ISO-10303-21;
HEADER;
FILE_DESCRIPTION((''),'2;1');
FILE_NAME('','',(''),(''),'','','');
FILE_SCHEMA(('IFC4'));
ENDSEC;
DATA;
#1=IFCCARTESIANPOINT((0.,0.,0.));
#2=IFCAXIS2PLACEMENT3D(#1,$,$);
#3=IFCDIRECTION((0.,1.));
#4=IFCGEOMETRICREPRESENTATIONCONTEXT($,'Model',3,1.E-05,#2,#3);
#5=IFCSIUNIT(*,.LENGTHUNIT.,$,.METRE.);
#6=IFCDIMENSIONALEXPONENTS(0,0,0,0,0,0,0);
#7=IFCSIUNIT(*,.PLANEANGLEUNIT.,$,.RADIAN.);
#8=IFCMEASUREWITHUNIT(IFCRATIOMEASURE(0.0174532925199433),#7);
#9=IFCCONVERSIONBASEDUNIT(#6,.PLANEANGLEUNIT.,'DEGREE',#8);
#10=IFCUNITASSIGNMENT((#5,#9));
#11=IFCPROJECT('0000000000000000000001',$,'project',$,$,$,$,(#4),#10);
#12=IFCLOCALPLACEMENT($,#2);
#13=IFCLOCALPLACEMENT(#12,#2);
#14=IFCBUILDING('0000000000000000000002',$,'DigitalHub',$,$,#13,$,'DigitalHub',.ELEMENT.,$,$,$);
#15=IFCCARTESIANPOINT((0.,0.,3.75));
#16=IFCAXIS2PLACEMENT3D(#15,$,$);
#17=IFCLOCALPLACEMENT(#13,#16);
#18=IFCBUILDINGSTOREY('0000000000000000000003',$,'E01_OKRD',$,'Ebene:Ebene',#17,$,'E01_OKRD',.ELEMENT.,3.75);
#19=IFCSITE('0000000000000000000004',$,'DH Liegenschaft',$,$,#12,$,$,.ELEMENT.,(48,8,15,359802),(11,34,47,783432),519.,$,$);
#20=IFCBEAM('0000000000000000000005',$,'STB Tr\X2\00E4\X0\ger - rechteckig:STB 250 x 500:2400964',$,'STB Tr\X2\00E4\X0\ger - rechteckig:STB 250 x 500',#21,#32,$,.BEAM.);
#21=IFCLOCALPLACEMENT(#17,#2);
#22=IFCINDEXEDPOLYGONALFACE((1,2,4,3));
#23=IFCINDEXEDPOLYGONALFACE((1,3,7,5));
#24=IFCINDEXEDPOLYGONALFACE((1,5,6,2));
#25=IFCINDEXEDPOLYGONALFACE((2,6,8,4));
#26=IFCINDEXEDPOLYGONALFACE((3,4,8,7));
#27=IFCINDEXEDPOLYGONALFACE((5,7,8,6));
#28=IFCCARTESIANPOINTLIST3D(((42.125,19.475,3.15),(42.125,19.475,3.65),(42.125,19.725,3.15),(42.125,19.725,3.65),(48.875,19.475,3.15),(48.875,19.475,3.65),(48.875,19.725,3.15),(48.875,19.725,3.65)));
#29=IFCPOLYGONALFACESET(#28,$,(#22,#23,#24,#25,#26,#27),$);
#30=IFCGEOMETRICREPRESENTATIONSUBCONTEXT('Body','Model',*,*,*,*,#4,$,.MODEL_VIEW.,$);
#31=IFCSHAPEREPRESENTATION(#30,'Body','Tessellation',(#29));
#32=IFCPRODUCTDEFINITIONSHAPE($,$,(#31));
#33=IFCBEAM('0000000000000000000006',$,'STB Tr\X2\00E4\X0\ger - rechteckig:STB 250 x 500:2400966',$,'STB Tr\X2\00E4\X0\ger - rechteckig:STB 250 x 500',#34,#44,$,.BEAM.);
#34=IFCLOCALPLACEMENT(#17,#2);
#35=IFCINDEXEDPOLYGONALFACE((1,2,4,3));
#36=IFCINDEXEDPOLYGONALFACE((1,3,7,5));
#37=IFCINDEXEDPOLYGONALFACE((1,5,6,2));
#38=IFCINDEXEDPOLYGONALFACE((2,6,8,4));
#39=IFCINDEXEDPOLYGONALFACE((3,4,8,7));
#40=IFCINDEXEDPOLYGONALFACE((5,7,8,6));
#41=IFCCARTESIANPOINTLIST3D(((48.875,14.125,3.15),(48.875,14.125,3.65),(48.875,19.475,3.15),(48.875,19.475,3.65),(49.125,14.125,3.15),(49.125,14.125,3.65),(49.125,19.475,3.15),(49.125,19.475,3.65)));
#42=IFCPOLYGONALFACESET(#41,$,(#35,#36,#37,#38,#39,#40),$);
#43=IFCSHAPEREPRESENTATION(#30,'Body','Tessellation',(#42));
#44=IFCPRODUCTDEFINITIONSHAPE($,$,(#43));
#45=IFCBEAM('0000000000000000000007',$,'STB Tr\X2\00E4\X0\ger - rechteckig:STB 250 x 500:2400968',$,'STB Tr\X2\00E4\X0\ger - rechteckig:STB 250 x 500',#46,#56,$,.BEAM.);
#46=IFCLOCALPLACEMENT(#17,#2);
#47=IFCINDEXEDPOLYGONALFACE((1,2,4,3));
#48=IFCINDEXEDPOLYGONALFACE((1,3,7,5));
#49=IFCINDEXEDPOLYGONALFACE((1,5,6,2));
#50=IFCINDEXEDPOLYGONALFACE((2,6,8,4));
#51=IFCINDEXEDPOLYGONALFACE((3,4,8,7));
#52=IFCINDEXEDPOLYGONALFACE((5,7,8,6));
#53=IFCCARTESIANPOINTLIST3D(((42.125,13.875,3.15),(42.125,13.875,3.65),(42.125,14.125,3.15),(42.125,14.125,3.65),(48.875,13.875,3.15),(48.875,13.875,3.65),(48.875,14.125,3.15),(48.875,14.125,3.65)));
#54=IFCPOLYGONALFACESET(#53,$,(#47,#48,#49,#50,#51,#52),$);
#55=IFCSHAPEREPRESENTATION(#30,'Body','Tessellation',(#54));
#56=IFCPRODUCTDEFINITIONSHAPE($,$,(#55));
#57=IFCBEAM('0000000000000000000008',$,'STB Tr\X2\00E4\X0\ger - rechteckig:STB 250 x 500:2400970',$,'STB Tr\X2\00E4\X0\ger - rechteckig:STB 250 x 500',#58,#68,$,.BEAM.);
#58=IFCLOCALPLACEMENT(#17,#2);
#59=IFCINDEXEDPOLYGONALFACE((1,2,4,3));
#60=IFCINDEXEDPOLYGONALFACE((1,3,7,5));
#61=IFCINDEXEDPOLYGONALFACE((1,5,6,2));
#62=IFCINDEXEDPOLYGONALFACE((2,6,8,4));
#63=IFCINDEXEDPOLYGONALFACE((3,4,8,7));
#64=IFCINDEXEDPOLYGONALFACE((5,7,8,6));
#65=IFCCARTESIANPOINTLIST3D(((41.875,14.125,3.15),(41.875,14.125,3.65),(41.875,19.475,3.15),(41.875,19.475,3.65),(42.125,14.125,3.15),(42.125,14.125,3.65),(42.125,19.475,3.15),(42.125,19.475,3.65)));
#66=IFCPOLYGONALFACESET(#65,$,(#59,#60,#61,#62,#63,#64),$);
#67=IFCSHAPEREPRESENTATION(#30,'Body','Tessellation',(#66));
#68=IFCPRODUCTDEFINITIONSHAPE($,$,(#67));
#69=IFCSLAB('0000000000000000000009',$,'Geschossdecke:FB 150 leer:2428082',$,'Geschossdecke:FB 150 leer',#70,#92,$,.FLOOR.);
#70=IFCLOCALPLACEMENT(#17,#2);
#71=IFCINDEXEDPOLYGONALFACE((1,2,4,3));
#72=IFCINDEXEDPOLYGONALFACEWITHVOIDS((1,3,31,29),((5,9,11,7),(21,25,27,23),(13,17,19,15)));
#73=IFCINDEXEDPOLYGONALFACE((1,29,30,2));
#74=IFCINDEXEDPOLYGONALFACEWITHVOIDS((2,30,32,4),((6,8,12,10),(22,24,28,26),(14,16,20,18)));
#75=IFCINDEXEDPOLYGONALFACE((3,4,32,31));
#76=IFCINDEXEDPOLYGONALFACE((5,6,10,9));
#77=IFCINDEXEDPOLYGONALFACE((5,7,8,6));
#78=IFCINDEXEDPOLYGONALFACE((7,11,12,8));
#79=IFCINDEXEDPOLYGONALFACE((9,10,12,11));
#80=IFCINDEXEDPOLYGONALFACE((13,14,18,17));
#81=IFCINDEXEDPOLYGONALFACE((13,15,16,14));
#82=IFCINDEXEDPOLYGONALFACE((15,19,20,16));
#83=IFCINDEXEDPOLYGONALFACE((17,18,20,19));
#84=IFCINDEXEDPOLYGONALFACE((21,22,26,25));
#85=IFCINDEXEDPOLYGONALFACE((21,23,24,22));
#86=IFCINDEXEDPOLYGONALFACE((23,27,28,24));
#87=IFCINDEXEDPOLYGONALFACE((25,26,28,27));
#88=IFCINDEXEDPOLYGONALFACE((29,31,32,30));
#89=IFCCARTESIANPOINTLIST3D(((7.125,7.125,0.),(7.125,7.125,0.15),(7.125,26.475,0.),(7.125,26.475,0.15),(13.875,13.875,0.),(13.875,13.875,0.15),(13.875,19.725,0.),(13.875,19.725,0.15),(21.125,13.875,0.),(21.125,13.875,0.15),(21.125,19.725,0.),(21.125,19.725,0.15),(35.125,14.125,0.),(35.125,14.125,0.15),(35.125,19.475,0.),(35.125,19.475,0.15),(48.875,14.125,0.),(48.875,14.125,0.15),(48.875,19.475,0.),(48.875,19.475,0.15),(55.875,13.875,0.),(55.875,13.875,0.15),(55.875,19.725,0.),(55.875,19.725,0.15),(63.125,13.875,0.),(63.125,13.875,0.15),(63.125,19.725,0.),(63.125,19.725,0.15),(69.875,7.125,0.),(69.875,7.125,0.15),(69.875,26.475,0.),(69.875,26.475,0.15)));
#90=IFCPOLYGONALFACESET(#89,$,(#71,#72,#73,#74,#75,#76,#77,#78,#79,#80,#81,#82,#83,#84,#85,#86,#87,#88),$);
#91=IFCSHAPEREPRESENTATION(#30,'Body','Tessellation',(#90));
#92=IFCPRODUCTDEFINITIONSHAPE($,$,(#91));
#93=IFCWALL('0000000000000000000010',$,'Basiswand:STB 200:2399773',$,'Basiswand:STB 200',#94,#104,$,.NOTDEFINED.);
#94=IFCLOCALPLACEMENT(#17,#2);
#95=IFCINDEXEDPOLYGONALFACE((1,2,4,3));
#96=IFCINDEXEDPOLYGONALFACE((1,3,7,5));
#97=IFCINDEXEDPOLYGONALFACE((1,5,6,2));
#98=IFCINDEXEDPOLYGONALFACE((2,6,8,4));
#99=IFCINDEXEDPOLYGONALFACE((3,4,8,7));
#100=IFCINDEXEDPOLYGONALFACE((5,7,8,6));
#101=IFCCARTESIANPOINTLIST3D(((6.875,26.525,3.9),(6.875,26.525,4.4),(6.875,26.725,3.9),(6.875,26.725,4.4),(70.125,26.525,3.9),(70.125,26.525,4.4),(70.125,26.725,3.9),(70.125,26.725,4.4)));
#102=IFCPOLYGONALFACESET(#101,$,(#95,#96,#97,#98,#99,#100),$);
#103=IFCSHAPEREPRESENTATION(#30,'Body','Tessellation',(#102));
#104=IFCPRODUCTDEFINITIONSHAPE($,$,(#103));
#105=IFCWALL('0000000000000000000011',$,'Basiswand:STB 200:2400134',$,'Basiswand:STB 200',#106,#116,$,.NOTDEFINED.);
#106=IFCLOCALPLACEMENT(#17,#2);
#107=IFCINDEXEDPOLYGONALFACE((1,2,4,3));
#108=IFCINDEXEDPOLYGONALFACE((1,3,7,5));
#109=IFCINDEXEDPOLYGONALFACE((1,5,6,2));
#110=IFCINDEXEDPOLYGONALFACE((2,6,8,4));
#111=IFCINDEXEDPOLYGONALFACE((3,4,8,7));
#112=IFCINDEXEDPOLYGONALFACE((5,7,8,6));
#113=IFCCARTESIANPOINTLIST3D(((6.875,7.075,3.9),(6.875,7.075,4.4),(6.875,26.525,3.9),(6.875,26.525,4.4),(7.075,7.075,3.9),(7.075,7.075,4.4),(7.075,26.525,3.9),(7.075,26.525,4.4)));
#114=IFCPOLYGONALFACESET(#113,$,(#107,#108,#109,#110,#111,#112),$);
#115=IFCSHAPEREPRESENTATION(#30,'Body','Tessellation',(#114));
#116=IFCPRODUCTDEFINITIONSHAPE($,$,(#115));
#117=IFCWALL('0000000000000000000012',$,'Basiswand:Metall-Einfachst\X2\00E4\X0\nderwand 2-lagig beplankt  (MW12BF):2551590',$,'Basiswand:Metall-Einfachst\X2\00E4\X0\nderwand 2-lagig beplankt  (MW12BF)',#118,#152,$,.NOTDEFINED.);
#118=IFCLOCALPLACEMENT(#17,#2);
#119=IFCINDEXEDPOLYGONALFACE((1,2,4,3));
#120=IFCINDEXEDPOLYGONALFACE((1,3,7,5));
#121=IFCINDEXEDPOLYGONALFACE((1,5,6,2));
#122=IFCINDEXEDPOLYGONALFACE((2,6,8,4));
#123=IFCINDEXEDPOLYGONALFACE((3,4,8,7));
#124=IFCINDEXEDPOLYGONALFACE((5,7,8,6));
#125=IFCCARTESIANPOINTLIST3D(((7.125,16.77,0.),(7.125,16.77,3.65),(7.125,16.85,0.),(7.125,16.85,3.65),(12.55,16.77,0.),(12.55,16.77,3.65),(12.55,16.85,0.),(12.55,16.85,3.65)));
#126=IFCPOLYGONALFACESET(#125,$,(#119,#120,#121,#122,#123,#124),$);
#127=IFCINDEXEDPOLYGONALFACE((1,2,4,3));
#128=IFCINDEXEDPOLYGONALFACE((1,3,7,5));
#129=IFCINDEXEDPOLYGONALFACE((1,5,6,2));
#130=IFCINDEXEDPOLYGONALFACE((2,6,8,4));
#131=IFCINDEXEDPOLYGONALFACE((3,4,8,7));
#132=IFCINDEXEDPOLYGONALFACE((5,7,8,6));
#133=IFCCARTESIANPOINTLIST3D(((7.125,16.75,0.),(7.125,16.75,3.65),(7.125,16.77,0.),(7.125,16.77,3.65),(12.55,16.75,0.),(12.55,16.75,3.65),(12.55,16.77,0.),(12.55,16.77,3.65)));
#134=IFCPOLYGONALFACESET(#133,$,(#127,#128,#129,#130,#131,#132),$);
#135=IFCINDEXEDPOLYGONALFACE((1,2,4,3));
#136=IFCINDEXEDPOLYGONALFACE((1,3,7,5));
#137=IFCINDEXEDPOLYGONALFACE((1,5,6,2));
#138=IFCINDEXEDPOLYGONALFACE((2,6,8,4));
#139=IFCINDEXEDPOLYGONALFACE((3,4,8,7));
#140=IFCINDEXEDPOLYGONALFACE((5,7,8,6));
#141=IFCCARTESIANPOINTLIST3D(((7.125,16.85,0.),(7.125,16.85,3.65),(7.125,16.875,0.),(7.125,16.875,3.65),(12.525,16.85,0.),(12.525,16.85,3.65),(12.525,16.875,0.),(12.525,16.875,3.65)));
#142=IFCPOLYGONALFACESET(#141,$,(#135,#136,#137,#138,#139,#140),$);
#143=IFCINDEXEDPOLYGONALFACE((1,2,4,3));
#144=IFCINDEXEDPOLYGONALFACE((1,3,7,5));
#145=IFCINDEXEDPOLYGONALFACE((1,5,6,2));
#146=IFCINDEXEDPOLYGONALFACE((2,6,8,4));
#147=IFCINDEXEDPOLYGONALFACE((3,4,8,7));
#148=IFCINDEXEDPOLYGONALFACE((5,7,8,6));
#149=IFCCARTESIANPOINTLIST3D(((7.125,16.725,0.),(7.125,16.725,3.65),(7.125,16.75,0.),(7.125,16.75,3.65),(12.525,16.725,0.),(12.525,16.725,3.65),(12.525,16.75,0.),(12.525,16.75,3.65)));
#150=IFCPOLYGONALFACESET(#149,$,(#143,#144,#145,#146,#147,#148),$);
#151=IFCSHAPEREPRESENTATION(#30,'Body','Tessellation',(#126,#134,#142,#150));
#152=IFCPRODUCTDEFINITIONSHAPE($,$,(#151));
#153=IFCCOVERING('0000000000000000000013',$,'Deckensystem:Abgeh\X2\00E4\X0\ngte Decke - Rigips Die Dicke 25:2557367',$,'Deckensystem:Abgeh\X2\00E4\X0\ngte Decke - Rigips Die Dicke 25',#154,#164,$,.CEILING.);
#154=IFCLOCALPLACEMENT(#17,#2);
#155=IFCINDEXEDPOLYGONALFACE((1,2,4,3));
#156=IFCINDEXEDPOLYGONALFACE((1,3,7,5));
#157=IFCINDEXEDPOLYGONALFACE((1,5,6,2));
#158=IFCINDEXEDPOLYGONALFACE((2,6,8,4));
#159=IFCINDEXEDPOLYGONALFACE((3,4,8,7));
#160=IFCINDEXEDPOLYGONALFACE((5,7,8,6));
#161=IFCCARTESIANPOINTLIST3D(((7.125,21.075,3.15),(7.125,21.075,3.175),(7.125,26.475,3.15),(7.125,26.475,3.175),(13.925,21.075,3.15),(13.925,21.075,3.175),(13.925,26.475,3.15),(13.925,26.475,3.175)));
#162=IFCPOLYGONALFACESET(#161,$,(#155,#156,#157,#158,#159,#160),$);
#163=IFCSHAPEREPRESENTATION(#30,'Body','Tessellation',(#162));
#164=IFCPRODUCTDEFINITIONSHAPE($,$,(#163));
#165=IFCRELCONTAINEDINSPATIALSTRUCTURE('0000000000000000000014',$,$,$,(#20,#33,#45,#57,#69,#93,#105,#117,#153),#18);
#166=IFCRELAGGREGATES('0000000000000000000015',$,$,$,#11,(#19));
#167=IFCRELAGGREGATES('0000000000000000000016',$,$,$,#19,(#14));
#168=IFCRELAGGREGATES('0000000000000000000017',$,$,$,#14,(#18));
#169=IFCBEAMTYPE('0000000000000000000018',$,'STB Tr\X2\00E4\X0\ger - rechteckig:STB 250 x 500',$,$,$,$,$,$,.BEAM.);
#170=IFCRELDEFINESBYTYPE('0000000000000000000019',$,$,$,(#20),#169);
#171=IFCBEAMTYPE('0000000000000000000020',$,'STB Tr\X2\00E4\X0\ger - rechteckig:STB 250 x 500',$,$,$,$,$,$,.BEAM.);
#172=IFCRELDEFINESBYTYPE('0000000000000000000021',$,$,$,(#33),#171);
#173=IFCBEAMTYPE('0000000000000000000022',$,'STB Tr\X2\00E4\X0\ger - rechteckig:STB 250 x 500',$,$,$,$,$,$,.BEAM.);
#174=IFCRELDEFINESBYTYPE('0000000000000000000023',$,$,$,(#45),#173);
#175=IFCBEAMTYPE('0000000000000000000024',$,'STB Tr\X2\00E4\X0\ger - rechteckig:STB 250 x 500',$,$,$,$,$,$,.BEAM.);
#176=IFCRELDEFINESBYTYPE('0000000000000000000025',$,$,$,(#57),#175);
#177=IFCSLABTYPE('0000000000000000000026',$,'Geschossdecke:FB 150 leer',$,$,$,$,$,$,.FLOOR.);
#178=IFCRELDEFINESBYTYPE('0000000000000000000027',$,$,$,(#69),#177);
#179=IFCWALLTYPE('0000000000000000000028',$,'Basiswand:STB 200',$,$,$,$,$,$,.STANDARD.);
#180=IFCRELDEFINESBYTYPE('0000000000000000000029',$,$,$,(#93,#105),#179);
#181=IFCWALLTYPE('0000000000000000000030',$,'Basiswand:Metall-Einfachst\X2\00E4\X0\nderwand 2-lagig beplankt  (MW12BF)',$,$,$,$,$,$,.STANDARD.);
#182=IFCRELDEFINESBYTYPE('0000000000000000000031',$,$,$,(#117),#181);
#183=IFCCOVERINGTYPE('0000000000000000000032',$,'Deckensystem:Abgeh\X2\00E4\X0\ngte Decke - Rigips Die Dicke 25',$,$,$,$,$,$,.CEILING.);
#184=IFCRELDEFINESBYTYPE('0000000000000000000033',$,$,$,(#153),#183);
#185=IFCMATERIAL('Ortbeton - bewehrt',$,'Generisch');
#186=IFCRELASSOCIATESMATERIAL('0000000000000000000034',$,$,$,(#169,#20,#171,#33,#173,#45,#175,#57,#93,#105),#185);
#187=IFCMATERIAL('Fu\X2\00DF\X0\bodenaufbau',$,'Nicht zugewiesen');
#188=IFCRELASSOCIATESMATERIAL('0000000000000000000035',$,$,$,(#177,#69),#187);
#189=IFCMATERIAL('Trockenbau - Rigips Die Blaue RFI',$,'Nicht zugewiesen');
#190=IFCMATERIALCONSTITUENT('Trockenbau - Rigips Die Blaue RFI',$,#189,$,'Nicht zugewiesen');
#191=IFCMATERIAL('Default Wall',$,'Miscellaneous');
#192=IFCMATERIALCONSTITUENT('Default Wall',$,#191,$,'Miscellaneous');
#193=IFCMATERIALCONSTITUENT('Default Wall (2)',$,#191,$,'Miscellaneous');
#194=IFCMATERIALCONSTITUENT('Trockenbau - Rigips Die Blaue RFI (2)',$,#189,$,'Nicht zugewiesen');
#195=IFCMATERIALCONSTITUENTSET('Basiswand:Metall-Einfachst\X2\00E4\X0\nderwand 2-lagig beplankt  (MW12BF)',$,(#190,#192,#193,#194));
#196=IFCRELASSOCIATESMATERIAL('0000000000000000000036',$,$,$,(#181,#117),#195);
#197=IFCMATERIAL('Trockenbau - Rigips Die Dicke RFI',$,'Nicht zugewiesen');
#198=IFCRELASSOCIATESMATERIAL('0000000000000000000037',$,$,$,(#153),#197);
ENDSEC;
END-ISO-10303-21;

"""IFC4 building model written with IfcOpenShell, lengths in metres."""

from ifc_helpers import new_model, entity, si_unit, converted_unit, direction, frame, origin, place, context, subcontext, project, spatial, indexed_curve, outline, extrude, source, transform, mapped, material, constituent, constituent_set, type_object, type_shapes, element, save


model = new_model("IFC4")

# Units and contexts
model_context = context("Model", 3, precision=1e-05, world=origin(), true_north=direction((0.0, 1.0)))
body_context = subcontext(model_context, "Body", "Model", "MODEL_VIEW")
ifc_project = project(units=[si_unit("LENGTHUNIT", "METRE"), converted_unit("PLANEANGLEUNIT", "DEGREE", entity("IfcRatioMeasure", 0.0174532925199433), si_unit("PLANEANGLEUNIT", "RADIAN"), dimensions=[0, 0, 0, 0, 0, 0, 0])], contexts=[model_context])

# Site, building, storey
site_placement = place(None, frame((0.0, 0.0, 0.0)))
site = spatial("IfcSite", under=ifc_project, at=site_placement, Name="DH Liegenschaft", CompositionType="ELEMENT", RefLatitude=(48, 8, 15, 359802), RefLongitude=(11, 34, 47, 783432), RefElevation=519.0)
building_placement = place(site_placement, origin())
building = spatial("IfcBuilding", under=site, at=building_placement, Name="DigitalHub", LongName="DigitalHub", CompositionType="ELEMENT")
storey_placement = place(building_placement, frame((0.0, 0.0, 3.75)))
storey = spatial("IfcBuildingStorey", under=building, at=storey_placement, Name="E01_OKRD", ObjectType="Ebene:Ebene", LongName="E01_OKRD", CompositionType="ELEMENT", Elevation=3.75)

# Shared definitions
ifc_material_1 = material(Name="Ortbeton - bewehrt", Category="Generisch")

# Beams
beam_type_1 = type_object("IfcBeamType", Name="STB Träger - rechteckig:STB 250 x 500", PredefinedType="BEAM", material=ifc_material_1)
shared_shape_1 = source(origin(), body_context, "Body", "SweptSolid", [
    extrude(outline(indexed_curve([(-0.25, -0.125), (0.25, -0.125), (0.25, 0.125), (-0.25, 0.125), (-0.25, -0.125)], self_intersect=False)), frame((42.125, 19.6, 7.15), z_axis=(1.0, 0.0, 0.0), x_axis=(0.0, 0.0, -1.0)), (0.0, 0.0, 1.0), 6.75),
])
type_shapes(beam_type_1, [shared_shape_1])
beam_1_placement = place(storey_placement, frame((0.0, 0.0, -3.75)))
element("IfcBeam", 1, at=beam_1_placement, inside=storey, type_object=beam_type_1, material=ifc_material_1, Name="STB Träger - rechteckig:STB 250 x 500:2400964", ObjectType="STB Träger - rechteckig:STB 250 x 500", PredefinedType="BEAM", context=body_context, shape_type="MappedRepresentation", body=[
    mapped(shared_shape_1, transform((0.0, 0.0, 0.0), scale=1.0)),
])
beam_type_2 = type_object("IfcBeamType", Name="STB Träger - rechteckig:STB 250 x 500", PredefinedType="BEAM", material=ifc_material_1)
shared_shape_2 = source(origin(), body_context, "Body", "SweptSolid", [
    extrude(outline(indexed_curve([(-0.125, -0.25), (0.125, -0.25), (0.125, 0.25), (-0.125, 0.25), (-0.125, -0.25)], self_intersect=False)), frame((49.0, 19.475, 7.15), z_axis=(0.0, -1.0, 0.0), x_axis=(-1.0, 0.0, 0.0)), (0.0, 0.0, 1.0), 5.35),
])
type_shapes(beam_type_2, [shared_shape_2])
beam_2_placement = place(storey_placement, frame((0.0, 0.0, -3.75)))
element("IfcBeam", 2, at=beam_2_placement, inside=storey, type_object=beam_type_2, material=ifc_material_1, Name="STB Träger - rechteckig:STB 250 x 500:2400966", ObjectType="STB Träger - rechteckig:STB 250 x 500", PredefinedType="BEAM", context=body_context, shape_type="MappedRepresentation", body=[
    mapped(shared_shape_2, transform((0.0, 0.0, 0.0), scale=1.0)),
])
beam_type_3 = type_object("IfcBeamType", Name="STB Träger - rechteckig:STB 250 x 500", PredefinedType="BEAM", material=ifc_material_1)
shared_shape_3 = source(origin(), body_context, "Body", "SweptSolid", [
    extrude(outline(indexed_curve([(-0.25, -0.125), (0.25, -0.125), (0.25, 0.125), (-0.25, 0.125), (-0.25, -0.125)], self_intersect=False)), frame((48.875, 14.0, 7.15), z_axis=(-1.0, 0.0, 0.0), x_axis=(0.0, 0.0, -1.0)), (0.0, 0.0, 1.0), 6.75),
])
type_shapes(beam_type_3, [shared_shape_3])
beam_3_placement = place(storey_placement, frame((0.0, 0.0, -3.75)))
element("IfcBeam", 3, at=beam_3_placement, inside=storey, type_object=beam_type_3, material=ifc_material_1, Name="STB Träger - rechteckig:STB 250 x 500:2400968", ObjectType="STB Träger - rechteckig:STB 250 x 500", PredefinedType="BEAM", context=body_context, shape_type="MappedRepresentation", body=[
    mapped(shared_shape_3, transform((0.0, 0.0, 0.0), scale=1.0)),
])
beam_type_4 = type_object("IfcBeamType", Name="STB Träger - rechteckig:STB 250 x 500", PredefinedType="BEAM", material=ifc_material_1)
shared_shape_4 = source(origin(), body_context, "Body", "SweptSolid", [
    extrude(outline(indexed_curve([(-0.125, -0.25), (0.125, -0.25), (0.125, 0.25), (-0.125, 0.25), (-0.125, -0.25)], self_intersect=False)), frame((42.0, 14.125, 7.15), z_axis=(0.0, 1.0, 0.0), x_axis=(-1.0, 0.0, 0.0)), (0.0, 0.0, 1.0), 5.35),
])
type_shapes(beam_type_4, [shared_shape_4])
beam_4_placement = place(storey_placement, frame((0.0, 0.0, -3.75)))
element("IfcBeam", 4, at=beam_4_placement, inside=storey, type_object=beam_type_4, material=ifc_material_1, Name="STB Träger - rechteckig:STB 250 x 500:2400970", ObjectType="STB Träger - rechteckig:STB 250 x 500", PredefinedType="BEAM", context=body_context, shape_type="MappedRepresentation", body=[
    mapped(shared_shape_4, transform((0.0, 0.0, 0.0), scale=1.0)),
])

# Slab
ifc_material_2 = material(Name="Fußbodenaufbau", Category="Nicht zugewiesen")
slab_type = type_object("IfcSlabType", Name="Geschossdecke:FB 150 leer", PredefinedType="FLOOR", material=ifc_material_2)
slab_placement = place(storey_placement, origin())
element("IfcSlab", 5, at=slab_placement, inside=storey, type_object=slab_type, material=ifc_material_2, Name="Geschossdecke:FB 150 leer:2428082", ObjectType="Geschossdecke:FB 150 leer", PredefinedType="FLOOR", context=body_context, shape_type="SweptSolid", body=[
    extrude(outline(indexed_curve([(-31.375, -9.675), (31.375, -9.675), (31.375, 9.675), (-31.375, 9.675), (-31.375, -9.675)], self_intersect=False), holes=[indexed_curve([(-24.625, 2.925), (-17.375, 2.925), (-17.375, -2.925), (-24.625, -2.925), (-24.625, 2.925)], self_intersect=False), indexed_curve([(3.375, 2.675), (3.375, -2.675), (-10.375, -2.675), (-10.375, 2.675), (3.375, 2.675)], self_intersect=False), indexed_curve([(24.625, 2.925), (24.625, -2.925), (17.375, -2.925), (17.375, 2.925), (24.625, 2.925)], self_intersect=False)]), frame((38.5, 16.8, 0.0), z_axis=(0.0, 0.0, 1.0), x_axis=(-1.0, 0.0, 0.0)), (0.0, 0.0, 1.0), 0.15),
])

# Walls
wall_type_1 = type_object("IfcWallType", Name="Basiswand:STB 200", PredefinedType="STANDARD")
wall_1_placement = place(storey_placement, frame((6.875, 26.625, 3.9)))
element("IfcWall", 6, at=wall_1_placement, inside=storey, type_object=wall_type_1, material=ifc_material_1, Name="Basiswand:STB 200:2399773", ObjectType="Basiswand:STB 200", PredefinedType="NOTDEFINED", context=body_context, shape_type="SweptSolid", body=[
    extrude(outline(indexed_curve([(63.25, 0.1), (0.0, 0.1), (0.0, -0.1), (63.25, -0.1), (63.25, 0.1)], self_intersect=False)), origin(), (0.0, 0.0, 1.0), 0.5),
])
wall_2_placement = place(storey_placement, frame((6.975, 7.075, 3.9), z_axis=(0.0, 0.0, 1.0), x_axis=(0.0, 1.0, 0.0)))
element("IfcWall", 7, at=wall_2_placement, inside=storey, type_object=wall_type_1, material=ifc_material_1, Name="Basiswand:STB 200:2400134", ObjectType="Basiswand:STB 200", PredefinedType="NOTDEFINED", context=body_context, shape_type="SweptSolid", body=[
    extrude(outline(indexed_curve([(19.45, 0.1), (0.0, 0.1), (0.0, -0.1), (19.45, -0.1), (19.45, 0.1)], self_intersect=False)), origin(), (0.0, 0.0, 1.0), 0.5),
])

# Shared definitions
ifc_material_3 = material(Name="Trockenbau - Rigips Die Blaue RFI", Category="Nicht zugewiesen")
ifc_constituent_1 = constituent(ifc_material_3, Name="Trockenbau - Rigips Die Blaue RFI", Category="Nicht zugewiesen")
ifc_material_4 = material(Name="Default Wall", Category="Miscellaneous")
ifc_constituent_2 = constituent(ifc_material_4, Name="Default Wall", Category="Miscellaneous")
ifc_constituent_3 = constituent(ifc_material_4, Name="Default Wall (2)", Category="Miscellaneous")
ifc_constituent_4 = constituent(ifc_material_3, Name="Trockenbau - Rigips Die Blaue RFI (2)", Category="Nicht zugewiesen")
ifc_constituent_set_1 = constituent_set(constituents=[ifc_constituent_1, ifc_constituent_2, ifc_constituent_3, ifc_constituent_4], Name="Basiswand:Metall-Einfachständerwand 2-lagig beplankt  (MW12BF)")
wall_type_2 = type_object("IfcWallType", Name="Basiswand:Metall-Einfachständerwand 2-lagig beplankt  (MW12BF)", PredefinedType="STANDARD", material=ifc_constituent_set_1)

# Wall
wall_3_placement = place(storey_placement, frame((7.125, 16.8, 0.0)))
element("IfcWall", 8, at=wall_3_placement, inside=storey, type_object=wall_type_2, material=ifc_constituent_set_1, Name="Basiswand:Metall-Einfachständerwand 2-lagig beplankt  (MW12BF):2551590", ObjectType="Basiswand:Metall-Einfachständerwand 2-lagig beplankt  (MW12BF)", PredefinedType="NOTDEFINED", context=body_context, shape_type="SweptSolid", body=[
    extrude(outline(indexed_curve([(-2.7125, -0.04), (2.7125, -0.04), (2.7125, 0.04), (-2.7125, 0.04), (-2.7125, -0.04)], self_intersect=False)), frame((2.7125, 0.01, 0.0)), (0.0, 0.0, 1.0), 3.65),
    extrude(outline(indexed_curve([(-2.7125, -0.01), (2.7125, -0.01), (2.7125, 0.01), (-2.7125, 0.01), (-2.7125, -0.01)], self_intersect=False)), frame((2.7125, -0.04, 0.0)), (0.0, 0.0, 1.0), 3.65),
    extrude(outline(indexed_curve([(-0.0125, -2.7), (0.0125, -2.7), (0.0125, 2.7), (-0.0125, 2.7), (-0.0125, -2.7)], self_intersect=False)), frame((2.7, 0.0625, 0.0), z_axis=(0.0, 0.0, 1.0), x_axis=(0.0, -1.0, 0.0)), (0.0, 0.0, 1.0), 3.65),
    extrude(outline(indexed_curve([(-0.0125, -2.7), (0.0125, -2.7), (0.0125, 2.7), (-0.0125, 2.7), (-0.0125, -2.7)], self_intersect=False)), frame((2.7, -0.0625, 0.0), z_axis=(0.0, 0.0, 1.0), x_axis=(0.0, 1.0, 0.0)), (0.0, 0.0, 1.0), 3.65),
])

# Covering
ifc_material_5 = material(Name="Trockenbau - Rigips Die Dicke RFI", Category="Nicht zugewiesen")
covering_type_1 = type_object("IfcCoveringType", Name="Deckensystem:Abgehängte Decke - Rigips Die Dicke 25", PredefinedType="CEILING")
covering_1_placement = place(storey_placement, frame((7.125, 21.075, 3.15)))
element("IfcCovering", 9, at=covering_1_placement, inside=storey, type_object=covering_type_1, material=ifc_material_5, Name="Deckensystem:Abgehängte Decke - Rigips Die Dicke 25:2557367", ObjectType="Deckensystem:Abgehängte Decke - Rigips Die Dicke 25", PredefinedType="CEILING", context=body_context, shape_type="SweptSolid", body=[
    extrude(outline(indexed_curve([(-3.4, -2.7), (3.4, -2.7), (3.4, 2.7), (-3.4, 2.7), (-3.4, -2.7)], self_intersect=False)), frame((3.4, 2.7, 0.0), z_axis=(0.0, 0.0, 1.0), x_axis=(-1.0, 0.0, 0.0)), (0.0, 0.0, 1.0), 0.025),
])

save(model, "model.ifc")
